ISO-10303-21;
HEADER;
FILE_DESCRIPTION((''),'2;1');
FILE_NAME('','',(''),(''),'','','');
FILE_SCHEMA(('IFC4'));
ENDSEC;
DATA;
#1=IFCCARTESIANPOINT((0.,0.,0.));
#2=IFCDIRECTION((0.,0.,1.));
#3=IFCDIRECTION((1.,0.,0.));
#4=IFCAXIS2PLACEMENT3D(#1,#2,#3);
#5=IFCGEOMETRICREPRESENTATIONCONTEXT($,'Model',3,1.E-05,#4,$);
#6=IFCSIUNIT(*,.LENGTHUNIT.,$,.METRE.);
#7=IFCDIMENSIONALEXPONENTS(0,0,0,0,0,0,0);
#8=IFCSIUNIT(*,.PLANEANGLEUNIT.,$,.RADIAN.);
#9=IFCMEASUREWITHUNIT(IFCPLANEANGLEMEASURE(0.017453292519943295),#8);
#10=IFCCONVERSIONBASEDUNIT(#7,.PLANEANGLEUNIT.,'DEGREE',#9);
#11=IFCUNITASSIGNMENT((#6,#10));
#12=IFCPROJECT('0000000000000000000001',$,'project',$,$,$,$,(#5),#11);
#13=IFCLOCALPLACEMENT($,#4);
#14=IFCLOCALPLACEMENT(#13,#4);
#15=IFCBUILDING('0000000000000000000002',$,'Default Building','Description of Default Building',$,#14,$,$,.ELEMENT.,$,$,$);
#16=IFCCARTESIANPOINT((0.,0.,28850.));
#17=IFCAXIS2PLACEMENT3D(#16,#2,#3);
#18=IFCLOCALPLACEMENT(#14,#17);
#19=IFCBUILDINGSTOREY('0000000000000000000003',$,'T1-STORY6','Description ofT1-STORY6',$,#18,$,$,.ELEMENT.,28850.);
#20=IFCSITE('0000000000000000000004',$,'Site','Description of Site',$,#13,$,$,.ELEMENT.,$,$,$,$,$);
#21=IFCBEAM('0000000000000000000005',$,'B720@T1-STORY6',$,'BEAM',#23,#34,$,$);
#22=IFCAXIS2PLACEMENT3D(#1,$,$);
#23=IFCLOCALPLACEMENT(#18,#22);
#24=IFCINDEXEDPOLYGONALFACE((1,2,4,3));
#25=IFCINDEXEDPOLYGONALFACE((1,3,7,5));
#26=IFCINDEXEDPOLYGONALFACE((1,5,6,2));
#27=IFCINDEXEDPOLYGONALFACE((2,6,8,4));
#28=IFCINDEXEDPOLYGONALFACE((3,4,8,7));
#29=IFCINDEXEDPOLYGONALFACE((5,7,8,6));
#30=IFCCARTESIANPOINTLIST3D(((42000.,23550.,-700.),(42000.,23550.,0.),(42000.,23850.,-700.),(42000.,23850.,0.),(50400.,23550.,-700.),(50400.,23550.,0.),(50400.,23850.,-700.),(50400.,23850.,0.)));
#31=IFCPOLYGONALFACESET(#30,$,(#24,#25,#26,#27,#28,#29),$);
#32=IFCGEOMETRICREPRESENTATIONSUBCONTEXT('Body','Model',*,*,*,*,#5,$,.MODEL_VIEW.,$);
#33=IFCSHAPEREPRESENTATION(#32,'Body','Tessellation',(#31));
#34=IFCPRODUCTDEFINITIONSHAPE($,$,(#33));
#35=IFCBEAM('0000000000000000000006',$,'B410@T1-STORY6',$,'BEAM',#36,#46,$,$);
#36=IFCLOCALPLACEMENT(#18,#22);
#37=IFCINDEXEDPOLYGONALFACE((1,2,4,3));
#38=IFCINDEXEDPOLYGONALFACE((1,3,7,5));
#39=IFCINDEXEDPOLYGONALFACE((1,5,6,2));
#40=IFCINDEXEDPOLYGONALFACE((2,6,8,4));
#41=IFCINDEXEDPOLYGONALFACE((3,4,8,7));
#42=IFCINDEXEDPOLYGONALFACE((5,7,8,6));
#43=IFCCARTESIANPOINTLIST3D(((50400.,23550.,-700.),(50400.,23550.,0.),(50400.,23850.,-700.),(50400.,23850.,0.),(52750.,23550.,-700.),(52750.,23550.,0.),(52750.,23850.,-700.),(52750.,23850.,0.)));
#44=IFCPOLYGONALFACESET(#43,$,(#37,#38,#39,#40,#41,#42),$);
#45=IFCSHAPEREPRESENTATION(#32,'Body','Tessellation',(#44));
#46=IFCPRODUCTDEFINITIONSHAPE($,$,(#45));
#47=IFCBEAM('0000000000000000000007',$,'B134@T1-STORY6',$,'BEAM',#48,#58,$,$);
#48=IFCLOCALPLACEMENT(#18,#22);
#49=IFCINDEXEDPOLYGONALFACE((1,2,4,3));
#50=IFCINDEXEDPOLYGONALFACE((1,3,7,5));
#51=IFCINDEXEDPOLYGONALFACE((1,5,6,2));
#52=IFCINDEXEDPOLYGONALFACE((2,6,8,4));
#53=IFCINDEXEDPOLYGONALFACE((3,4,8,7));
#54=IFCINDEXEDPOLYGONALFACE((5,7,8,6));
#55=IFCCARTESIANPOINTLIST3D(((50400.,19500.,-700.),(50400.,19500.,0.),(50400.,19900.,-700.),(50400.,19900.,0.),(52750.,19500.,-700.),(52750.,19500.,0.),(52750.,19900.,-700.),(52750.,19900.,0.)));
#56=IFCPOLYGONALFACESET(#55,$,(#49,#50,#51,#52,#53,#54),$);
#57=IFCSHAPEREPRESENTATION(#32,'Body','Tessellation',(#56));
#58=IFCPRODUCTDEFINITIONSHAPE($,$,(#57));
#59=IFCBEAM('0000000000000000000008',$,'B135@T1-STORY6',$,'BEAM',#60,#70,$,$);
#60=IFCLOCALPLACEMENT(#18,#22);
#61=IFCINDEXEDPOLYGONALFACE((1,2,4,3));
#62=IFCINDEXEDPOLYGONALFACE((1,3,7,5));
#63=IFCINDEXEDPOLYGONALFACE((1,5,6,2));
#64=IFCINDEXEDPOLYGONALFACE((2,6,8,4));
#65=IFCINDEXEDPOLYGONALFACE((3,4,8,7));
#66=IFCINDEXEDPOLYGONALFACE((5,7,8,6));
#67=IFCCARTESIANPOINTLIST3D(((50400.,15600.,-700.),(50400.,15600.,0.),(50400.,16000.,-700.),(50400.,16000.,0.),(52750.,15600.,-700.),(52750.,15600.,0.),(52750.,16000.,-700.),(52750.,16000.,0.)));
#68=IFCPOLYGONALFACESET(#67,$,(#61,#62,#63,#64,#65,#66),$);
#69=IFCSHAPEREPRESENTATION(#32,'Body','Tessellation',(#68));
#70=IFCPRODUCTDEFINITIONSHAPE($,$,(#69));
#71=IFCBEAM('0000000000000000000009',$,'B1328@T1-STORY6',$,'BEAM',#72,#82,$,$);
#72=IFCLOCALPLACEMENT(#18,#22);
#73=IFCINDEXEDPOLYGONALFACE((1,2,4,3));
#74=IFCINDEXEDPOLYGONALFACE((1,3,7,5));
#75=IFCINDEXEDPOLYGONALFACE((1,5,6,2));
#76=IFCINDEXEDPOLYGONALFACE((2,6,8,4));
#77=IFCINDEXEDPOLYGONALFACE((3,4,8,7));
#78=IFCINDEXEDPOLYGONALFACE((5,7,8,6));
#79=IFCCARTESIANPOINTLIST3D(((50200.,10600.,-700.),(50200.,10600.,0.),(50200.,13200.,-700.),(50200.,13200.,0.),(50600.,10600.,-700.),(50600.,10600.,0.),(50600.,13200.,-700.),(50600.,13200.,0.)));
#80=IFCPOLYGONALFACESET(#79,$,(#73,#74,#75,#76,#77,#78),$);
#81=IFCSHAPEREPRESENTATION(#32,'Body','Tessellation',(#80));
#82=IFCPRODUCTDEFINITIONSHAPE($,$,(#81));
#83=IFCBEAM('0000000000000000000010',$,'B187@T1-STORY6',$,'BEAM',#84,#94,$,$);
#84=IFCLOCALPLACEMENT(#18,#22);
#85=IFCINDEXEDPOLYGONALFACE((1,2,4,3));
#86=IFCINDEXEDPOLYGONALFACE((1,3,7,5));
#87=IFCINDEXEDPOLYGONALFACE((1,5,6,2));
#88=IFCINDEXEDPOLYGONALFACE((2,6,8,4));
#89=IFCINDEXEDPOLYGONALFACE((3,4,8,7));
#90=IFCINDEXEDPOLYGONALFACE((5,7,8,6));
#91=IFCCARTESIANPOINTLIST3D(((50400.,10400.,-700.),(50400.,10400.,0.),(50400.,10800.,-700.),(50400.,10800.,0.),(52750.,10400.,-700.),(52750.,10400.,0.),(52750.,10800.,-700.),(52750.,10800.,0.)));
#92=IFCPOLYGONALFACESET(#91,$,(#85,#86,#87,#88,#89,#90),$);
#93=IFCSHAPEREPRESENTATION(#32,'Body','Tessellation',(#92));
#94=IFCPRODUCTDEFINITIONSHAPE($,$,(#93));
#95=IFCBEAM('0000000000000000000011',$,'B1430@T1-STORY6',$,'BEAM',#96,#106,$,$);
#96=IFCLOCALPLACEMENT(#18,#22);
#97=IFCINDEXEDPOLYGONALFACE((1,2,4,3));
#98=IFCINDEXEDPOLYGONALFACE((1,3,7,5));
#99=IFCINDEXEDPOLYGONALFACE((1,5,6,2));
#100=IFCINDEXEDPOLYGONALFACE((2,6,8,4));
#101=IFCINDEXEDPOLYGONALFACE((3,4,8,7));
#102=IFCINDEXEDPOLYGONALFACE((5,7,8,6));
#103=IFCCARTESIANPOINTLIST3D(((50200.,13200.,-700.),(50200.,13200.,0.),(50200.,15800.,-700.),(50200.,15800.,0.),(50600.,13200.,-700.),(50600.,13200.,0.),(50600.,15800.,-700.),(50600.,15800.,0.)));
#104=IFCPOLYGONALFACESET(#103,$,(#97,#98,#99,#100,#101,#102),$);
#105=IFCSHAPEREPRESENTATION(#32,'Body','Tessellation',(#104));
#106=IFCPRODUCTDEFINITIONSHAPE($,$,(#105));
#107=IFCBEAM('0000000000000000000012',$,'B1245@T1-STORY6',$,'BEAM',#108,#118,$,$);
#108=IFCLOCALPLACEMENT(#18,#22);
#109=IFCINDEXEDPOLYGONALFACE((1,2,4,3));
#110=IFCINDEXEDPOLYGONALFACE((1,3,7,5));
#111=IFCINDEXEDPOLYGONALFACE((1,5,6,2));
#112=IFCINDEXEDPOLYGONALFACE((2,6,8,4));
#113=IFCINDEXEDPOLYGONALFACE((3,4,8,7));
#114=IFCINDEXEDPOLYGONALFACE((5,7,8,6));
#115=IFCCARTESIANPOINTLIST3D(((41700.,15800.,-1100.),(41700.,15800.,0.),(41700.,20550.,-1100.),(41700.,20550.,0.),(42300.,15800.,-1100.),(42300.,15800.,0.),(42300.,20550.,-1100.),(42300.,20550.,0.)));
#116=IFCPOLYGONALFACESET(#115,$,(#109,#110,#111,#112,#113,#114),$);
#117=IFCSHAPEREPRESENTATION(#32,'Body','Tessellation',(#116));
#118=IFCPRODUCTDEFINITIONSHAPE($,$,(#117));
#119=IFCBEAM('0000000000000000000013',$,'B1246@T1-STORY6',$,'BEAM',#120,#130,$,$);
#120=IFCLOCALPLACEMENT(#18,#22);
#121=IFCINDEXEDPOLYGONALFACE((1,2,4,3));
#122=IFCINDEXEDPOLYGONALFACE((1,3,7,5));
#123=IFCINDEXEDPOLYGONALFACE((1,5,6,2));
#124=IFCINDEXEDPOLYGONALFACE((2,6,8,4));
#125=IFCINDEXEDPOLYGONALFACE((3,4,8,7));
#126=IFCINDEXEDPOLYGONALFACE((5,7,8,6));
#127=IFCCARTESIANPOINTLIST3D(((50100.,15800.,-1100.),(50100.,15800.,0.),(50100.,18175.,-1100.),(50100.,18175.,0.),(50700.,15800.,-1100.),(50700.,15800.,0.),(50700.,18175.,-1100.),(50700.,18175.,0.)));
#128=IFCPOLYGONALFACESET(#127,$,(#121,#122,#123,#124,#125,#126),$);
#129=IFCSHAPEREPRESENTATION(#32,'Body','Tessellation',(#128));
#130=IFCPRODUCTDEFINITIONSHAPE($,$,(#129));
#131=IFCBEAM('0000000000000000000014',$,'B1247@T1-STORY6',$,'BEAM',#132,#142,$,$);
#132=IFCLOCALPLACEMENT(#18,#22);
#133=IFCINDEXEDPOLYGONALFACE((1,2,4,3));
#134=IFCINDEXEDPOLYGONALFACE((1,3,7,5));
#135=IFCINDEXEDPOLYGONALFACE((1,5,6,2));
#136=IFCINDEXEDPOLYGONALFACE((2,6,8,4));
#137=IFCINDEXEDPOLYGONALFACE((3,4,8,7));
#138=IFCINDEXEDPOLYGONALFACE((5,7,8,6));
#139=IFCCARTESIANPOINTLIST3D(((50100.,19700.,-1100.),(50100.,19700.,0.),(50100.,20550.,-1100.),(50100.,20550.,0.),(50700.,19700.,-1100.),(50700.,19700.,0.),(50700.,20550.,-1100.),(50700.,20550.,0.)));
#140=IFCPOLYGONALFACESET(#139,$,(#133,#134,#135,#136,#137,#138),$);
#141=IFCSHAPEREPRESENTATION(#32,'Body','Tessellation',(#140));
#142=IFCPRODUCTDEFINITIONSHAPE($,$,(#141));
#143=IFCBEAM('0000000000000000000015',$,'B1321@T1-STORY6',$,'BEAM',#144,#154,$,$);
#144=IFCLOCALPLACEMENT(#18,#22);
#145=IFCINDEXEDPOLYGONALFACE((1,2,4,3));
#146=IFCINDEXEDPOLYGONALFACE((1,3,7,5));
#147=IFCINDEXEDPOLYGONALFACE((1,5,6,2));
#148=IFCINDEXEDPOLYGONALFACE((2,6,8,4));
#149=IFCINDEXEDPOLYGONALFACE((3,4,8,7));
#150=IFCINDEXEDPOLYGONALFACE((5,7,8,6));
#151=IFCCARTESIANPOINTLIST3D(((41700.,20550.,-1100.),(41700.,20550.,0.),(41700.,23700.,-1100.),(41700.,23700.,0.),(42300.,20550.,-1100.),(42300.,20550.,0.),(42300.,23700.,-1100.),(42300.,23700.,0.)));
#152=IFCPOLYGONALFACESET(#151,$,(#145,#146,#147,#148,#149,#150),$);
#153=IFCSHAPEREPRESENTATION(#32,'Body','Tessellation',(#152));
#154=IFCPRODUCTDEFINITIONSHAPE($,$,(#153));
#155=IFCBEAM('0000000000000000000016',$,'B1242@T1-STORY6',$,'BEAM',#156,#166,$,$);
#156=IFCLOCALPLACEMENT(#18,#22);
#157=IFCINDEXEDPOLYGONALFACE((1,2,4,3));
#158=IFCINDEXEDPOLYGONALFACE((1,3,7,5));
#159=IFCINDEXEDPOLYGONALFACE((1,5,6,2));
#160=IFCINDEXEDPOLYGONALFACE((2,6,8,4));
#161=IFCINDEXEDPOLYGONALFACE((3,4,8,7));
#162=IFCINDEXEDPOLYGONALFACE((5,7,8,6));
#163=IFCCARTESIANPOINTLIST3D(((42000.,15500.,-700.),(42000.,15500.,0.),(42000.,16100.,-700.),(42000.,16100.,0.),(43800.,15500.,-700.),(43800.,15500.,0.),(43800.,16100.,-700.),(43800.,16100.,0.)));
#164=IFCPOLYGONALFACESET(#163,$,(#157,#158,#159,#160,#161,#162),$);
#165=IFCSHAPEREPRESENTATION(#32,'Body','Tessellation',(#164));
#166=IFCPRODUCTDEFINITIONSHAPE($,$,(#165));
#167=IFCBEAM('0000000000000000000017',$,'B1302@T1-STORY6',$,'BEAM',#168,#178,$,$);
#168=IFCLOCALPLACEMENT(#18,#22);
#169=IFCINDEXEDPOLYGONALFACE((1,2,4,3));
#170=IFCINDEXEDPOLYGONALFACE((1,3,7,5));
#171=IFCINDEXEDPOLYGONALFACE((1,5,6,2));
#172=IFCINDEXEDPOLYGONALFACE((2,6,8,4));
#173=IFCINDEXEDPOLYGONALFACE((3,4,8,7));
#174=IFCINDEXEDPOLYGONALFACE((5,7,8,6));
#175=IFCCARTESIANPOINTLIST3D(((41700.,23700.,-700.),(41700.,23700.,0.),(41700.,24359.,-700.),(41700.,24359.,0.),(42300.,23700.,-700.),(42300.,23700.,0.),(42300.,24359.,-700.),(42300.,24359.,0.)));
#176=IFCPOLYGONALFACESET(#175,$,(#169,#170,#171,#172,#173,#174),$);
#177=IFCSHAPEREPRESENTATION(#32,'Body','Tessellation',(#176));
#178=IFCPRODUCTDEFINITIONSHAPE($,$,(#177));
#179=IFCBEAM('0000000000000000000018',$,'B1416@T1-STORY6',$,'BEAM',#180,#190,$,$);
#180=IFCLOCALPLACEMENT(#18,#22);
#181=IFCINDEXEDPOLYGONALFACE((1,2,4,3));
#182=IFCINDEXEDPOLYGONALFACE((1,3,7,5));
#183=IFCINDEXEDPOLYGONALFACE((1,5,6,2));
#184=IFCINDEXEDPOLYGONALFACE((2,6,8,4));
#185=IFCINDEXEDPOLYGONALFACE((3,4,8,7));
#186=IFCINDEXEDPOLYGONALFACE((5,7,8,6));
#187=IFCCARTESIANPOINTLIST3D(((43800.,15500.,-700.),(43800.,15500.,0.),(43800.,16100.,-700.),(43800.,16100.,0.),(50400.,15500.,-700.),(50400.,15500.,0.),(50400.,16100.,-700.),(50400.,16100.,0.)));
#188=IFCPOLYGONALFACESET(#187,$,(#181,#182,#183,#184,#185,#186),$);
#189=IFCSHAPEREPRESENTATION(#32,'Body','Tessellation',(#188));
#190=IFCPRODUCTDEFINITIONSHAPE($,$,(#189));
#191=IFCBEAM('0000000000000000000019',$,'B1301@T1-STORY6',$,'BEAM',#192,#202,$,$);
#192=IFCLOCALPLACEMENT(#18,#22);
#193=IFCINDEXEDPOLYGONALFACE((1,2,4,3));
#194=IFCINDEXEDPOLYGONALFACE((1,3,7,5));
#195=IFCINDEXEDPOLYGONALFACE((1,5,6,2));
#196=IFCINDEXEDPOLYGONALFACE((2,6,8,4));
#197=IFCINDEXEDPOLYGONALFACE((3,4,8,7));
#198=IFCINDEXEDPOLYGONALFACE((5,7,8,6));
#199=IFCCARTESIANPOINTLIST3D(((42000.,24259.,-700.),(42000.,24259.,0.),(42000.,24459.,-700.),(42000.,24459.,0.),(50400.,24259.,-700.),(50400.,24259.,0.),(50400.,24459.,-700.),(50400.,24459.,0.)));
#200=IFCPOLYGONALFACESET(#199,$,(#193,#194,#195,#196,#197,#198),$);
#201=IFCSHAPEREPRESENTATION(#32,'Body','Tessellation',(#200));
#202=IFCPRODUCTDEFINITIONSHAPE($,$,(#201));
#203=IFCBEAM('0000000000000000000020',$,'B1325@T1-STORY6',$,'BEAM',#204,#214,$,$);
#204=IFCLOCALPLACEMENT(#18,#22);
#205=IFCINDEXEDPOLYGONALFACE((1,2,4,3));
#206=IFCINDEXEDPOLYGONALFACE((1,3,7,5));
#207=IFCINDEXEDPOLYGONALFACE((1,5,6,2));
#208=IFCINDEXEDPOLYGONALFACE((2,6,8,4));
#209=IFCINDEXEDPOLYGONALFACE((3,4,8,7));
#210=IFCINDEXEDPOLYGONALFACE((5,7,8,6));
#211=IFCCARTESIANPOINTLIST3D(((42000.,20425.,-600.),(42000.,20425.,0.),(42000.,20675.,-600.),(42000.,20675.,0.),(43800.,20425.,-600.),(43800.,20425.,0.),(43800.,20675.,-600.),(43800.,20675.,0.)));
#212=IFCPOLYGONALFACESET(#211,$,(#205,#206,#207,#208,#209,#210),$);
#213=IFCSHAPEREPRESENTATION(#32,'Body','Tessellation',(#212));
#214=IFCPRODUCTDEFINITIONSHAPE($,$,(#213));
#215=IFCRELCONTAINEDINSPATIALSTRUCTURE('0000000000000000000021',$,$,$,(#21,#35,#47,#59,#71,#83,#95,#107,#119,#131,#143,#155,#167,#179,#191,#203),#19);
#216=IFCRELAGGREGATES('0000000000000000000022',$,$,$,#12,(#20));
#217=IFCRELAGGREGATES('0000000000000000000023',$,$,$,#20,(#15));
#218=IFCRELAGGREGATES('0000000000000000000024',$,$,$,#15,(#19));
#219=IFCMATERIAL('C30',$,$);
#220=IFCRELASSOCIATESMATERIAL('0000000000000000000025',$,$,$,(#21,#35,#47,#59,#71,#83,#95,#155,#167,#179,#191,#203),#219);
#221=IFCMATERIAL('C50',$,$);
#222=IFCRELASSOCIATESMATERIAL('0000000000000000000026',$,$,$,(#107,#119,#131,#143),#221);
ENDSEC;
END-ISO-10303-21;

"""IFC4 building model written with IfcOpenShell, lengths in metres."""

from ifc_helpers import new_model, entity, si_unit, converted_unit, frame, origin_with_axes, place, context, subcontext, project, spatial, rectangle, extrude, material, element, save


model = new_model("IFC4")

# Units and contexts
model_context = context("Model", 3, precision=1e-05, world=origin_with_axes())
body_context = subcontext(model_context, "Body", "Model", "MODEL_VIEW")
ifc_project = project(units=[si_unit("LENGTHUNIT", "METRE"), converted_unit("PLANEANGLEUNIT", "DEGREE", entity("IfcPlaneAngleMeasure", 0.017453292519943295), si_unit("PLANEANGLEUNIT", "RADIAN"), dimensions=[0, 0, 0, 0, 0, 0, 0])], contexts=[model_context])

# Site, building, storey
site_placement = place(None, origin_with_axes())
site = spatial("IfcSite", under=ifc_project, at=site_placement, Name="Site", Description="Description of Site", CompositionType="ELEMENT")
building_placement = place(site_placement, origin_with_axes())
building = spatial("IfcBuilding", under=site, at=building_placement, Name="Default Building", Description="Description of Default Building", CompositionType="ELEMENT")
storey_placement = place(building_placement, frame((0.0, 0.0, 28850.0), z_axis=(0.0, 0.0, 1.0), x_axis=(1.0, 0.0, 0.0)))
storey = spatial("IfcBuildingStorey", under=building, at=storey_placement, Name="T1-STORY6", Description="Description ofT1-STORY6", CompositionType="ELEMENT", Elevation=28850.0)

# Beams
ifc_material_1 = material(Name="C30")
beam_1_placement = place(storey_placement, frame((42000.0, 23700.0, -350.0), z_axis=(1.0, 0.0, 0.0), x_axis=(0.0, 1.0, 0.0)))
element("IfcBeam", 1, at=beam_1_placement, inside=storey, material=ifc_material_1, Name="B720@T1-STORY6", ObjectType="BEAM", context=body_context, shape_type="SweptSolid", body=[
    extrude(rectangle(XDim=300.0, YDim=700.0), origin_with_axes(), (0.0, 0.0, 1.0), 8400.0),
])
beam_2_placement = place(storey_placement, frame((50400.0, 23700.0, -350.0), z_axis=(1.0, 0.0, 0.0), x_axis=(0.0, 1.0, 0.0)))
element("IfcBeam", 2, at=beam_2_placement, inside=storey, material=ifc_material_1, Name="B410@T1-STORY6", ObjectType="BEAM", context=body_context, shape_type="SweptSolid", body=[
    extrude(rectangle(XDim=300.0, YDim=700.0), origin_with_axes(), (0.0, 0.0, 1.0), 2350.0),
])
for number, where, z_axis, x_axis, name in (
    (3, (50400.0, 19700.0, -350.0), (1.0, 0.0, 0.0), (0.0, 1.0, 0.0), "B134@T1-STORY6"),
    (4, (50400.0, 15800.0, -350.0), (1.0, 0.0, 0.0), (0.0, 1.0, 0.0), "B135@T1-STORY6"),
):
    element("IfcBeam", number, at=place(storey_placement, frame(where, z_axis=z_axis, x_axis=x_axis)), inside=storey, material=ifc_material_1, Name=name, ObjectType="BEAM", context=body_context, shape_type="SweptSolid", body=[
        extrude(rectangle(XDim=400.0, YDim=700.0), origin_with_axes(), (0.0, 0.0, 1.0), 2350.0),
    ])
beam_3_placement = place(storey_placement, frame((50400.0, 10600.0, -350.0), z_axis=(0.0, 1.0, 0.0), x_axis=(-1.0, 0.0, 0.0)))
element("IfcBeam", 5, at=beam_3_placement, inside=storey, material=ifc_material_1, Name="B1328@T1-STORY6", ObjectType="BEAM", context=body_context, shape_type="SweptSolid", body=[
    extrude(rectangle(XDim=400.0, YDim=700.0), origin_with_axes(), (0.0, 0.0, 1.0), 2600.0),
])
beam_4_placement = place(storey_placement, frame((50400.0, 10600.0, -350.0), z_axis=(1.0, 0.0, 0.0), x_axis=(0.0, 1.0, 0.0)))
element("IfcBeam", 6, at=beam_4_placement, inside=storey, material=ifc_material_1, Name="B187@T1-STORY6", ObjectType="BEAM", context=body_context, shape_type="SweptSolid", body=[
    extrude(rectangle(XDim=400.0, YDim=700.0), origin_with_axes(), (0.0, 0.0, 1.0), 2350.0),
])
beam_5_placement = place(storey_placement, frame((50400.0, 13200.0, -350.0), z_axis=(0.0, 1.0, 0.0), x_axis=(-1.0, 0.0, 0.0)))
element("IfcBeam", 7, at=beam_5_placement, inside=storey, material=ifc_material_1, Name="B1430@T1-STORY6", ObjectType="BEAM", context=body_context, shape_type="SweptSolid", body=[
    extrude(rectangle(XDim=400.0, YDim=700.0), origin_with_axes(), (0.0, 0.0, 1.0), 2600.0),
])
ifc_material_2 = material(Name="C50")
beam_6_placement = place(storey_placement, frame((42000.0, 15800.0, -550.0), z_axis=(0.0, 1.0, 0.0), x_axis=(-1.0, 0.0, 0.0)))
element("IfcBeam", 8, at=beam_6_placement, inside=storey, material=ifc_material_2, Name="B1245@T1-STORY6", ObjectType="BEAM", context=body_context, shape_type="SweptSolid", body=[
    extrude(rectangle(XDim=600.0, YDim=1100.0), origin_with_axes(), (0.0, 0.0, 1.0), 4750.0),
])
beam_7_placement = place(storey_placement, frame((50400.0, 15800.0, -550.0), z_axis=(0.0, 1.0, 0.0), x_axis=(-1.0, 0.0, 0.0)))
element("IfcBeam", 9, at=beam_7_placement, inside=storey, material=ifc_material_2, Name="B1246@T1-STORY6", ObjectType="BEAM", context=body_context, shape_type="SweptSolid", body=[
    extrude(rectangle(XDim=600.0, YDim=1100.0), origin_with_axes(), (0.0, 0.0, 1.0), 2375.0),
])
beam_8_placement = place(storey_placement, frame((50400.0, 19700.0, -550.0), z_axis=(0.0, 1.0, 0.0), x_axis=(-1.0, 0.0, 0.0)))
element("IfcBeam", 10, at=beam_8_placement, inside=storey, material=ifc_material_2, Name="B1247@T1-STORY6", ObjectType="BEAM", context=body_context, shape_type="SweptSolid", body=[
    extrude(rectangle(XDim=600.0, YDim=1100.0), origin_with_axes(), (0.0, 0.0, 1.0), 850.0),
])
beam_9_placement = place(storey_placement, frame((42000.0, 20550.0, -550.0), z_axis=(0.0, 1.0, 0.0), x_axis=(-1.0, 0.0, 0.0)))
element("IfcBeam", 11, at=beam_9_placement, inside=storey, material=ifc_material_2, Name="B1321@T1-STORY6", ObjectType="BEAM", context=body_context, shape_type="SweptSolid", body=[
    extrude(rectangle(XDim=600.0, YDim=1100.0), origin_with_axes(), (0.0, 0.0, 1.0), 3150.0),
])
beam_10_placement = place(storey_placement, frame((42000.0, 15800.0, -350.0), z_axis=(1.0, 0.0, 0.0), x_axis=(0.0, 1.0, 0.0)))
element("IfcBeam", 12, at=beam_10_placement, inside=storey, material=ifc_material_1, Name="B1242@T1-STORY6", ObjectType="BEAM", context=body_context, shape_type="SweptSolid", body=[
    extrude(rectangle(XDim=600.0, YDim=700.0), origin_with_axes(), (0.0, 0.0, 1.0), 1800.0),
])
beam_11_placement = place(storey_placement, frame((42000.0, 23700.0, -350.0), z_axis=(0.0, 1.0, 0.0), x_axis=(-1.0, 0.0, 0.0)))
element("IfcBeam", 13, at=beam_11_placement, inside=storey, material=ifc_material_1, Name="B1302@T1-STORY6", ObjectType="BEAM", context=body_context, shape_type="SweptSolid", body=[
    extrude(rectangle(XDim=600.0, YDim=700.0), origin_with_axes(), (0.0, 0.0, 1.0), 659.0),
])
beam_12_placement = place(storey_placement, frame((43800.0, 15800.0, -350.0), z_axis=(1.0, 0.0, 0.0), x_axis=(0.0, 1.0, 0.0)))
element("IfcBeam", 14, at=beam_12_placement, inside=storey, material=ifc_material_1, Name="B1416@T1-STORY6", ObjectType="BEAM", context=body_context, shape_type="SweptSolid", body=[
    extrude(rectangle(XDim=600.0, YDim=700.0), origin_with_axes(), (0.0, 0.0, 1.0), 6600.0),
])
beam_13_placement = place(storey_placement, frame((42000.0, 24359.0, -350.0), z_axis=(1.0, 0.0, 0.0), x_axis=(0.0, 1.0, 0.0)))
element("IfcBeam", 15, at=beam_13_placement, inside=storey, material=ifc_material_1, Name="B1301@T1-STORY6", ObjectType="BEAM", context=body_context, shape_type="SweptSolid", body=[
    extrude(rectangle(XDim=200.0, YDim=700.0), origin_with_axes(), (0.0, 0.0, 1.0), 8400.0),
])
beam_14_placement = place(storey_placement, frame((42000.0, 20550.0, -300.0), z_axis=(1.0, 0.0, 0.0), x_axis=(0.0, 1.0, 0.0)))
element("IfcBeam", 16, at=beam_14_placement, inside=storey, material=ifc_material_1, Name="B1325@T1-STORY6", ObjectType="BEAM", context=body_context, shape_type="SweptSolid", body=[
    extrude(rectangle(XDim=250.0, YDim=600.0), origin_with_axes(), (0.0, 0.0, 1.0), 1800.0),
])

save(model, "model.ifc")
